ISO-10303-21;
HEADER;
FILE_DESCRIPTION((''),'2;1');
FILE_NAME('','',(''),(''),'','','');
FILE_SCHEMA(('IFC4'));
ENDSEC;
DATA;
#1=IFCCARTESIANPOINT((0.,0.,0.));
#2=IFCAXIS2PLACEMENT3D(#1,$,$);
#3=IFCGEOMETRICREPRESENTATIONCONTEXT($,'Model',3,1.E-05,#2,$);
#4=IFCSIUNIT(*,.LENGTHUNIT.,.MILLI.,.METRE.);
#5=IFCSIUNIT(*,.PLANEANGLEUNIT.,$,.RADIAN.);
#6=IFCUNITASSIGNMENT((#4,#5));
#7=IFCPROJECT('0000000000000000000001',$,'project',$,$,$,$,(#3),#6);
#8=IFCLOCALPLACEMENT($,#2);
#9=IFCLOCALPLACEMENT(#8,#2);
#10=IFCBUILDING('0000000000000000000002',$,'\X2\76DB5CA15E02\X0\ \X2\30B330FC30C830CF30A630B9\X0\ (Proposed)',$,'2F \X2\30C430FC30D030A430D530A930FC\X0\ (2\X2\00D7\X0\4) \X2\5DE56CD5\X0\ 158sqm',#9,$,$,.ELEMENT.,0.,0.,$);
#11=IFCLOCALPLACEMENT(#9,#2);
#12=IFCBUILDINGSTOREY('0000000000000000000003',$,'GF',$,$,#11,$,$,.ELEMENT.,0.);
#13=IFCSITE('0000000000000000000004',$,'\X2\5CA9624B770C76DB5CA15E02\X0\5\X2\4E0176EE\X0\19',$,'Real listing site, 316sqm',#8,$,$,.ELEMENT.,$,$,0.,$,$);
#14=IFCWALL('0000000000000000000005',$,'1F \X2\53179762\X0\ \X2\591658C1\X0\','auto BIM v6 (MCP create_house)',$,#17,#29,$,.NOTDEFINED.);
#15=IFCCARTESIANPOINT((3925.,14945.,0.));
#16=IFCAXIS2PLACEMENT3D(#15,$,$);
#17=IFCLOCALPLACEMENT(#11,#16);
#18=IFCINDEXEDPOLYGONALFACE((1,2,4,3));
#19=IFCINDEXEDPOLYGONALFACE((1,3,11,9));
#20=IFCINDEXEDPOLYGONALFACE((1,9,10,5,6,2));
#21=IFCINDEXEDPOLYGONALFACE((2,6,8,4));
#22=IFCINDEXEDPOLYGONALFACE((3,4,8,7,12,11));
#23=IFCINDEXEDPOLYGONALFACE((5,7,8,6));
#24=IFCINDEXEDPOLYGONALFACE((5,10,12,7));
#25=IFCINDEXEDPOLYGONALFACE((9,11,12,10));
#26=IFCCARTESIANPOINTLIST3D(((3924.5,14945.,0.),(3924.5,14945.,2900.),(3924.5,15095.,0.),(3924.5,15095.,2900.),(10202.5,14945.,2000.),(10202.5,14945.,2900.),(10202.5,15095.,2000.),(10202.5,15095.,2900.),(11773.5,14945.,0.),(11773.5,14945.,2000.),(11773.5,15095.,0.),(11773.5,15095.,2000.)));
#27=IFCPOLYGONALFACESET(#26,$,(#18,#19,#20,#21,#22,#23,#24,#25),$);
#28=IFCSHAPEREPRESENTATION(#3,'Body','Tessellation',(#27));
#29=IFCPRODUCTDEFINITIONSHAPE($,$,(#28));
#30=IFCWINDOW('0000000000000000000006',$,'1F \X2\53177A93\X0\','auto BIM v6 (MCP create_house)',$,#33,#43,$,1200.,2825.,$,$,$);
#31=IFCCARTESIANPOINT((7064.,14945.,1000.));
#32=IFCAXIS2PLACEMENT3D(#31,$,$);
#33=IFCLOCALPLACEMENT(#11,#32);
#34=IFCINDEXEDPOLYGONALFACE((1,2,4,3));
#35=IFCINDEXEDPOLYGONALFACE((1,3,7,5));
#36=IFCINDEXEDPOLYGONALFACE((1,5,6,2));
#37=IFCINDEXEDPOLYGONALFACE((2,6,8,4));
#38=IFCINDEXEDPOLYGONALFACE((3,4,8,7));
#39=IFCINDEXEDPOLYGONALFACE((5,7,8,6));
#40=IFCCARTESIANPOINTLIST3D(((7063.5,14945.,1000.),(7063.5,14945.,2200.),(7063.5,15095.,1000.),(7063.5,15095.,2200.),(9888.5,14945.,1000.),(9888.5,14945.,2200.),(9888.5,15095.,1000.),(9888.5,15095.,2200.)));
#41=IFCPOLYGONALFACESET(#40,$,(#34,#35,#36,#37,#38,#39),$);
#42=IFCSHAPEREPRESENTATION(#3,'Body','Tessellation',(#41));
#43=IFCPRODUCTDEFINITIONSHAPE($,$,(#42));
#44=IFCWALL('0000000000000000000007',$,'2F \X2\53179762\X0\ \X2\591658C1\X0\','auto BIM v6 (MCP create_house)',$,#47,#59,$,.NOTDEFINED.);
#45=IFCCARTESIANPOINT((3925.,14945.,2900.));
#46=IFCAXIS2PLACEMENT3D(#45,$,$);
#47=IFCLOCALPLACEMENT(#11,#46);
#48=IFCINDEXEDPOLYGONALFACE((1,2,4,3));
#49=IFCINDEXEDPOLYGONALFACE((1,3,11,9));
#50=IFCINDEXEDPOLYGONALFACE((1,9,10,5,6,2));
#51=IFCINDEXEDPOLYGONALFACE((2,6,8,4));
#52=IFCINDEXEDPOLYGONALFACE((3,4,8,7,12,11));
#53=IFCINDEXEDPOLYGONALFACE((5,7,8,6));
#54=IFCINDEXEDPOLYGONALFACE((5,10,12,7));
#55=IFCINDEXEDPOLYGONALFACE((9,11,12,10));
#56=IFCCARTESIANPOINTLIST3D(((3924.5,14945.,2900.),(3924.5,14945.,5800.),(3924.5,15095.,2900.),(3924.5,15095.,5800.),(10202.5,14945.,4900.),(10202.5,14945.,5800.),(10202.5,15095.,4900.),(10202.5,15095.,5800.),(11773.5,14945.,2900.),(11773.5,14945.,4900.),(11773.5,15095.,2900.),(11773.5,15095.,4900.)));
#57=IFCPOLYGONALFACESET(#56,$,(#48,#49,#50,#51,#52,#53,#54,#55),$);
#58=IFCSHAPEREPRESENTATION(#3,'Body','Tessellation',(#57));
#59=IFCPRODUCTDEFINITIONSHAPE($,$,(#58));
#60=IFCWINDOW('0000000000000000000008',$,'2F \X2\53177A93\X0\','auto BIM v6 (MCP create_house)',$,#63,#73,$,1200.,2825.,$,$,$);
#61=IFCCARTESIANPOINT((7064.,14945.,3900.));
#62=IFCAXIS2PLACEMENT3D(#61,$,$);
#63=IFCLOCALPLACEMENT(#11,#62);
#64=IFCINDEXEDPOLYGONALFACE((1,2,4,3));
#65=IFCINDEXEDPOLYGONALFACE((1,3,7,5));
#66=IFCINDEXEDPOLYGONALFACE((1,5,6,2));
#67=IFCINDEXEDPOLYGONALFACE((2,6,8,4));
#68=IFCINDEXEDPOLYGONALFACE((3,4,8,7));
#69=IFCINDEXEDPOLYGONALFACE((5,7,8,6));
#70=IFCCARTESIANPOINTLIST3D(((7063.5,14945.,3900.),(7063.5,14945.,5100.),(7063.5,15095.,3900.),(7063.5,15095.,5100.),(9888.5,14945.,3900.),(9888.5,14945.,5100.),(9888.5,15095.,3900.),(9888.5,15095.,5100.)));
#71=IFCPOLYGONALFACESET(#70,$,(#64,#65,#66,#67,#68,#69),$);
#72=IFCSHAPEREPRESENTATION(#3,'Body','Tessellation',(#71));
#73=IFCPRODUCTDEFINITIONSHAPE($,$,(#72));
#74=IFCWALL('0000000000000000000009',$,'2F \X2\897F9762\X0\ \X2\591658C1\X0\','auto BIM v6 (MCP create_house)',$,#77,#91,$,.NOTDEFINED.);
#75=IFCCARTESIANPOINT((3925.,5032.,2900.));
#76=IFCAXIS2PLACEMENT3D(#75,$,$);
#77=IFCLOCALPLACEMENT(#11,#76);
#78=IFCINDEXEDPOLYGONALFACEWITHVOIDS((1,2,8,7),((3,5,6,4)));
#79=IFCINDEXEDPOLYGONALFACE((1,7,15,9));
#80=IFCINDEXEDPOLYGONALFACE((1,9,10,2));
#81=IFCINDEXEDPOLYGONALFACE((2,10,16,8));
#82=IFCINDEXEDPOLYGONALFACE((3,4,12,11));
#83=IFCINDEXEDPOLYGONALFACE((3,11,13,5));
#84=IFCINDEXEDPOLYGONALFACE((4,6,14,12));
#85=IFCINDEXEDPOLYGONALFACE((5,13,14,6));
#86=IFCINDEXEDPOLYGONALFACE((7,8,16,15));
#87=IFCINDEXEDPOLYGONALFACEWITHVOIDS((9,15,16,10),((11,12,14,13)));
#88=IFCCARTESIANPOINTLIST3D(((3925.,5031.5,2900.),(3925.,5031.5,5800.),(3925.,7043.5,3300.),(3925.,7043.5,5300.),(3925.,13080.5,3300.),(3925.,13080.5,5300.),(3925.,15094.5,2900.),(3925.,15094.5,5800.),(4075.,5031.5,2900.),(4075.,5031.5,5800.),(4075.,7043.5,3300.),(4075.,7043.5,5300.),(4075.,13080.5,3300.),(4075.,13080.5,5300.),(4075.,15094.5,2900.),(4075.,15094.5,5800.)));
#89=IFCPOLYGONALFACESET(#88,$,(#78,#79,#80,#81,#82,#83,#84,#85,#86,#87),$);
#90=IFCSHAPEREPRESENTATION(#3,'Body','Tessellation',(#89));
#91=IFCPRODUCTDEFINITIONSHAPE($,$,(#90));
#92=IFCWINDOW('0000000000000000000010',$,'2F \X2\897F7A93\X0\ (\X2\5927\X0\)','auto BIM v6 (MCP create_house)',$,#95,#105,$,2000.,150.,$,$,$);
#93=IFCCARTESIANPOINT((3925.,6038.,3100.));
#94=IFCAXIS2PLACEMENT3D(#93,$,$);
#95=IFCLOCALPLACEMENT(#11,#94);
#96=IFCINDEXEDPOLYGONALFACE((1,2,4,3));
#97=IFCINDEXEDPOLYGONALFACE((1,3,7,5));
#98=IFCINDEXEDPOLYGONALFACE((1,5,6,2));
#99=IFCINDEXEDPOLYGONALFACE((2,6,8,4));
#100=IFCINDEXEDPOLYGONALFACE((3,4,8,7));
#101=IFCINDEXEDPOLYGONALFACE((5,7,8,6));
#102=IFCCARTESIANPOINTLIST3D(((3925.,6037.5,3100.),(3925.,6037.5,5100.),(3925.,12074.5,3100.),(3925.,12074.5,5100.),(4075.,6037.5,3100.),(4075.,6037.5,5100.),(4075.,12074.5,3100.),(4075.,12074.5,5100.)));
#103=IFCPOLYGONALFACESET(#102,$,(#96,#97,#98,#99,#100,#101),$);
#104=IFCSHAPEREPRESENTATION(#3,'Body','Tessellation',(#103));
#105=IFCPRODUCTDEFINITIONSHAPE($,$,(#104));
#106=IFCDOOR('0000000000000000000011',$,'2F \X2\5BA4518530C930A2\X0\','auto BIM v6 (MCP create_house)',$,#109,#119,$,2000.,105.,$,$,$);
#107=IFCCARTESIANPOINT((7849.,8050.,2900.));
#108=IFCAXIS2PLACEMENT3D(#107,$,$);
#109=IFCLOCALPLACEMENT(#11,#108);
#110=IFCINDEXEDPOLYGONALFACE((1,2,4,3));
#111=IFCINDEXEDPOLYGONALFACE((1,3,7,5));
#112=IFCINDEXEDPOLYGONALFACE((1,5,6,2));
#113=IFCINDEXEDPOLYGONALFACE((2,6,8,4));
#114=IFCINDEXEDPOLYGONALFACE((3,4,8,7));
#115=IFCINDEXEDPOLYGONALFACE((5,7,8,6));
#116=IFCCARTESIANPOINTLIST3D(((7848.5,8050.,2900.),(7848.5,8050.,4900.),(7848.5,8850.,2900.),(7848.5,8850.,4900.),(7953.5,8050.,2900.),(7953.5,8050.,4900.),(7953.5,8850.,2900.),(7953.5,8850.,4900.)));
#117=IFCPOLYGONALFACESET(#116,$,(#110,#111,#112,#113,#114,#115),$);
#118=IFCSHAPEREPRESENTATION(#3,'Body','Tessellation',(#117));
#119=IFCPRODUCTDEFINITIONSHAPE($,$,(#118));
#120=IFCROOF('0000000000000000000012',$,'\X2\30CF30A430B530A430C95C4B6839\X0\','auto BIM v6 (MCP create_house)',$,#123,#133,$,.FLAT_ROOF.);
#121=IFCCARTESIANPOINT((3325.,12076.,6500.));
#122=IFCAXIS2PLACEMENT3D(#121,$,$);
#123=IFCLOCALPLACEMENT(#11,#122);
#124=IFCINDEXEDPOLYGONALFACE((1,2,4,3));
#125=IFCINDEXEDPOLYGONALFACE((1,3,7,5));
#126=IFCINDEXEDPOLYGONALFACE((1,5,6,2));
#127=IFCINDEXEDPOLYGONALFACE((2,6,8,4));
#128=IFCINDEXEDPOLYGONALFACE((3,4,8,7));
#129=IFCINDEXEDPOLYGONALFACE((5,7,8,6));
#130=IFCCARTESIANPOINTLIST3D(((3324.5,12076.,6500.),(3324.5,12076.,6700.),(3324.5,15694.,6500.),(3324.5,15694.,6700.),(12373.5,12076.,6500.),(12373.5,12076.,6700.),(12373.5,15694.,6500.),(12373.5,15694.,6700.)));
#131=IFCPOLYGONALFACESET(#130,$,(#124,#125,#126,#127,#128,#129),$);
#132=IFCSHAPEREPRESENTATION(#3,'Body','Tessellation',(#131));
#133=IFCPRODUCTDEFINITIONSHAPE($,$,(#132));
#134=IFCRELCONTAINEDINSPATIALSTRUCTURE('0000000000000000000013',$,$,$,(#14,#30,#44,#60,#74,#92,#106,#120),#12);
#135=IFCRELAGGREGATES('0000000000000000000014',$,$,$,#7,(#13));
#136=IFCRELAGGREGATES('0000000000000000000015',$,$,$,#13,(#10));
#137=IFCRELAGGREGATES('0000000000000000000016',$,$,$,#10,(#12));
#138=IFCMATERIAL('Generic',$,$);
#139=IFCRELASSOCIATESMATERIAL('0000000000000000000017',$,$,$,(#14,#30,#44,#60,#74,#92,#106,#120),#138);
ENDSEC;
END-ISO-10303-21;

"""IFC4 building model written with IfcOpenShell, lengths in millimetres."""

from ifc_helpers import new_model, si_unit, frame, frame_2d, origin, place, context, project, spatial, rectangle, extrude, material, element, fill, save


model = new_model("IFC4")

# Units and contexts
model_context = context("Model", 3, precision=1e-05, world=origin())
ifc_project = project(units=[si_unit("LENGTHUNIT", "METRE", prefix="MILLI"), si_unit("PLANEANGLEUNIT", "RADIAN")], contexts=[model_context])

# Site, building, storey
site_placement = place(None, origin())
site = spatial("IfcSite", under=ifc_project, at=site_placement, Name="岩手県盛岡市5丁目19", ObjectType="Real listing site, 316sqm", CompositionType="ELEMENT", RefElevation=0.0)
building_placement = place(site_placement, origin())
building = spatial("IfcBuilding", under=site, at=building_placement, Name="盛岡市 コートハウス (Proposed)", ObjectType="2F ツーバイフォー (2×4) 工法 158sqm", CompositionType="ELEMENT", ElevationOfRefHeight=0.0, ElevationOfTerrain=0.0)
storey_placement = place(building_placement, origin())
storey = spatial("IfcBuildingStorey", under=building, at=storey_placement, Name="GF", CompositionType="ELEMENT", Elevation=0.0)

# Wall, opening, window
ifc_material = material(Name="Generic")
wall_1_placement = place(storey_placement, frame((3925.0, 14945.0, 0.0)))
wall_1 = element("IfcWall", 1, at=wall_1_placement, inside=storey, material=ifc_material, Name="1F 北面 外壁", Description="auto BIM v6 (MCP create_house)", PredefinedType="NOTDEFINED", context=model_context, shape_type="SweptSolid", body=[
    extrude(rectangle(XDim=7849.0, YDim=150.0, at=frame_2d((3924.0, 75.0))), frame((3925.0, 14945.0, 0.0)), (0.0, 0.0, 1.0), 2900.0),
])
opening_1_placement = place(storey_placement, frame((7064.0, 14945.0, 1000.0)))
opening_1 = element("IfcOpeningElement", 2, at=opening_1_placement, cuts=wall_1, PredefinedType="NOTDEFINED", context=model_context, shape_type="SweptSolid", body=[
    extrude(rectangle(XDim=2825.0, YDim=150.0, at=frame_2d((1412.0, 75.0))), frame((7064.0, 14945.0, 1000.0)), (0.0, 0.0, 1.0), 1200.0),
])
window_1_placement = place(storey_placement, frame((7064.0, 14945.0, 1000.0)))
window_1 = element("IfcWindow", 3, at=window_1_placement, inside=storey, material=ifc_material, Name="1F 北窓", Description="auto BIM v6 (MCP create_house)", OverallHeight=1200.0, OverallWidth=2825.0, context=model_context, shape_type="SweptSolid", body=[
    extrude(rectangle(XDim=2825.0, YDim=150.0, at=frame_2d((1412.0, 75.0))), frame((7064.0, 14945.0, 1000.0)), (0.0, 0.0, 1.0), 1200.0),
])
fill(opening_1, window_1)

# Walls, openings, windows
wall_2_placement = place(storey_placement, frame((3925.0, 14945.0, 2900.0)))
wall_2 = element("IfcWall", 4, at=wall_2_placement, inside=storey, material=ifc_material, Name="2F 北面 外壁", Description="auto BIM v6 (MCP create_house)", PredefinedType="NOTDEFINED", context=model_context, shape_type="SweptSolid", body=[
    extrude(rectangle(XDim=7849.0, YDim=150.0, at=frame_2d((3924.0, 75.0))), frame((3925.0, 14945.0, 2900.0)), (0.0, 0.0, 1.0), 2900.0),
])
opening_2_placement = place(storey_placement, frame((7064.0, 14945.0, 3900.0)))
opening_2 = element("IfcOpeningElement", 5, at=opening_2_placement, cuts=wall_2, PredefinedType="NOTDEFINED", context=model_context, shape_type="SweptSolid", body=[
    extrude(rectangle(XDim=2825.0, YDim=150.0, at=frame_2d((1412.0, 75.0))), frame((7064.0, 14945.0, 3900.0)), (0.0, 0.0, 1.0), 1200.0),
])
window_2_placement = place(storey_placement, frame((7064.0, 14945.0, 3900.0)))
window_2 = element("IfcWindow", 6, at=window_2_placement, inside=storey, material=ifc_material, Name="2F 北窓", Description="auto BIM v6 (MCP create_house)", OverallHeight=1200.0, OverallWidth=2825.0, context=model_context, shape_type="SweptSolid", body=[
    extrude(rectangle(XDim=2825.0, YDim=150.0, at=frame_2d((1412.0, 75.0))), frame((7064.0, 14945.0, 3900.0)), (0.0, 0.0, 1.0), 1200.0),
])
fill(opening_2, window_2)
wall_3_placement = place(storey_placement, frame((3925.0, 5032.0, 2900.0)))
wall_3 = element("IfcWall", 7, at=wall_3_placement, inside=storey, material=ifc_material, Name="2F 西面 外壁", Description="auto BIM v6 (MCP create_house)", PredefinedType="NOTDEFINED", context=model_context, shape_type="SweptSolid", body=[
    extrude(rectangle(XDim=150.0, YDim=10063.0, at=frame_2d((75.0, 5031.0))), frame((3925.0, 5032.0, 2900.0)), (0.0, 0.0, 1.0), 2900.0),
])
opening_3_placement = place(storey_placement, frame((3925.0, 6038.0, 3100.0)))
opening_3 = element("IfcOpeningElement", 8, at=opening_3_placement, cuts=wall_3, PredefinedType="NOTDEFINED", context=model_context, shape_type="SweptSolid", body=[
    extrude(rectangle(XDim=150.0, YDim=6037.0, at=frame_2d((75.0, 3018.0))), frame((3925.0, 6038.0, 3100.0)), (0.0, 0.0, 1.0), 2000.0),
])
window_3_placement = place(storey_placement, frame((3925.0, 6038.0, 3100.0)))
window_3 = element("IfcWindow", 9, at=window_3_placement, inside=storey, material=ifc_material, Name="2F 西窓 (大)", Description="auto BIM v6 (MCP create_house)", OverallHeight=2000.0, OverallWidth=150.0, context=model_context, shape_type="SweptSolid", body=[
    extrude(rectangle(XDim=150.0, YDim=6037.0, at=frame_2d((75.0, 3018.0))), frame((3925.0, 6038.0, 3100.0)), (0.0, 0.0, 1.0), 2000.0),
])
fill(opening_3, window_3)

# Door
door_placement = place(storey_placement, frame((7849.0, 8050.0, 2900.0)))
element("IfcDoor", 10, at=door_placement, inside=storey, material=ifc_material, Name="2F 室内ドア", Description="auto BIM v6 (MCP create_house)", OverallHeight=2000.0, OverallWidth=105.0, context=model_context, shape_type="SweptSolid", body=[
    extrude(rectangle(XDim=105.0, YDim=800.0, at=frame_2d((52.0, 400.0))), frame((7849.0, 8050.0, 2900.0)), (0.0, 0.0, 1.0), 2000.0),
])

# Roof
roof_placement = place(storey_placement, frame((3325.0, 12076.0, 6500.0)))
element("IfcRoof", 11, at=roof_placement, inside=storey, material=ifc_material, Name="ハイサイド屋根", Description="auto BIM v6 (MCP create_house)", PredefinedType="FLAT_ROOF", context=model_context, shape_type="SweptSolid", body=[
    extrude(rectangle(XDim=9049.0, YDim=3618.0, at=frame_2d((4524.0, 1809.0))), frame((3325.0, 12076.0, 6500.0)), (0.0, 0.0, 1.0), 200.0),
])

save(model, "model.ifc")
